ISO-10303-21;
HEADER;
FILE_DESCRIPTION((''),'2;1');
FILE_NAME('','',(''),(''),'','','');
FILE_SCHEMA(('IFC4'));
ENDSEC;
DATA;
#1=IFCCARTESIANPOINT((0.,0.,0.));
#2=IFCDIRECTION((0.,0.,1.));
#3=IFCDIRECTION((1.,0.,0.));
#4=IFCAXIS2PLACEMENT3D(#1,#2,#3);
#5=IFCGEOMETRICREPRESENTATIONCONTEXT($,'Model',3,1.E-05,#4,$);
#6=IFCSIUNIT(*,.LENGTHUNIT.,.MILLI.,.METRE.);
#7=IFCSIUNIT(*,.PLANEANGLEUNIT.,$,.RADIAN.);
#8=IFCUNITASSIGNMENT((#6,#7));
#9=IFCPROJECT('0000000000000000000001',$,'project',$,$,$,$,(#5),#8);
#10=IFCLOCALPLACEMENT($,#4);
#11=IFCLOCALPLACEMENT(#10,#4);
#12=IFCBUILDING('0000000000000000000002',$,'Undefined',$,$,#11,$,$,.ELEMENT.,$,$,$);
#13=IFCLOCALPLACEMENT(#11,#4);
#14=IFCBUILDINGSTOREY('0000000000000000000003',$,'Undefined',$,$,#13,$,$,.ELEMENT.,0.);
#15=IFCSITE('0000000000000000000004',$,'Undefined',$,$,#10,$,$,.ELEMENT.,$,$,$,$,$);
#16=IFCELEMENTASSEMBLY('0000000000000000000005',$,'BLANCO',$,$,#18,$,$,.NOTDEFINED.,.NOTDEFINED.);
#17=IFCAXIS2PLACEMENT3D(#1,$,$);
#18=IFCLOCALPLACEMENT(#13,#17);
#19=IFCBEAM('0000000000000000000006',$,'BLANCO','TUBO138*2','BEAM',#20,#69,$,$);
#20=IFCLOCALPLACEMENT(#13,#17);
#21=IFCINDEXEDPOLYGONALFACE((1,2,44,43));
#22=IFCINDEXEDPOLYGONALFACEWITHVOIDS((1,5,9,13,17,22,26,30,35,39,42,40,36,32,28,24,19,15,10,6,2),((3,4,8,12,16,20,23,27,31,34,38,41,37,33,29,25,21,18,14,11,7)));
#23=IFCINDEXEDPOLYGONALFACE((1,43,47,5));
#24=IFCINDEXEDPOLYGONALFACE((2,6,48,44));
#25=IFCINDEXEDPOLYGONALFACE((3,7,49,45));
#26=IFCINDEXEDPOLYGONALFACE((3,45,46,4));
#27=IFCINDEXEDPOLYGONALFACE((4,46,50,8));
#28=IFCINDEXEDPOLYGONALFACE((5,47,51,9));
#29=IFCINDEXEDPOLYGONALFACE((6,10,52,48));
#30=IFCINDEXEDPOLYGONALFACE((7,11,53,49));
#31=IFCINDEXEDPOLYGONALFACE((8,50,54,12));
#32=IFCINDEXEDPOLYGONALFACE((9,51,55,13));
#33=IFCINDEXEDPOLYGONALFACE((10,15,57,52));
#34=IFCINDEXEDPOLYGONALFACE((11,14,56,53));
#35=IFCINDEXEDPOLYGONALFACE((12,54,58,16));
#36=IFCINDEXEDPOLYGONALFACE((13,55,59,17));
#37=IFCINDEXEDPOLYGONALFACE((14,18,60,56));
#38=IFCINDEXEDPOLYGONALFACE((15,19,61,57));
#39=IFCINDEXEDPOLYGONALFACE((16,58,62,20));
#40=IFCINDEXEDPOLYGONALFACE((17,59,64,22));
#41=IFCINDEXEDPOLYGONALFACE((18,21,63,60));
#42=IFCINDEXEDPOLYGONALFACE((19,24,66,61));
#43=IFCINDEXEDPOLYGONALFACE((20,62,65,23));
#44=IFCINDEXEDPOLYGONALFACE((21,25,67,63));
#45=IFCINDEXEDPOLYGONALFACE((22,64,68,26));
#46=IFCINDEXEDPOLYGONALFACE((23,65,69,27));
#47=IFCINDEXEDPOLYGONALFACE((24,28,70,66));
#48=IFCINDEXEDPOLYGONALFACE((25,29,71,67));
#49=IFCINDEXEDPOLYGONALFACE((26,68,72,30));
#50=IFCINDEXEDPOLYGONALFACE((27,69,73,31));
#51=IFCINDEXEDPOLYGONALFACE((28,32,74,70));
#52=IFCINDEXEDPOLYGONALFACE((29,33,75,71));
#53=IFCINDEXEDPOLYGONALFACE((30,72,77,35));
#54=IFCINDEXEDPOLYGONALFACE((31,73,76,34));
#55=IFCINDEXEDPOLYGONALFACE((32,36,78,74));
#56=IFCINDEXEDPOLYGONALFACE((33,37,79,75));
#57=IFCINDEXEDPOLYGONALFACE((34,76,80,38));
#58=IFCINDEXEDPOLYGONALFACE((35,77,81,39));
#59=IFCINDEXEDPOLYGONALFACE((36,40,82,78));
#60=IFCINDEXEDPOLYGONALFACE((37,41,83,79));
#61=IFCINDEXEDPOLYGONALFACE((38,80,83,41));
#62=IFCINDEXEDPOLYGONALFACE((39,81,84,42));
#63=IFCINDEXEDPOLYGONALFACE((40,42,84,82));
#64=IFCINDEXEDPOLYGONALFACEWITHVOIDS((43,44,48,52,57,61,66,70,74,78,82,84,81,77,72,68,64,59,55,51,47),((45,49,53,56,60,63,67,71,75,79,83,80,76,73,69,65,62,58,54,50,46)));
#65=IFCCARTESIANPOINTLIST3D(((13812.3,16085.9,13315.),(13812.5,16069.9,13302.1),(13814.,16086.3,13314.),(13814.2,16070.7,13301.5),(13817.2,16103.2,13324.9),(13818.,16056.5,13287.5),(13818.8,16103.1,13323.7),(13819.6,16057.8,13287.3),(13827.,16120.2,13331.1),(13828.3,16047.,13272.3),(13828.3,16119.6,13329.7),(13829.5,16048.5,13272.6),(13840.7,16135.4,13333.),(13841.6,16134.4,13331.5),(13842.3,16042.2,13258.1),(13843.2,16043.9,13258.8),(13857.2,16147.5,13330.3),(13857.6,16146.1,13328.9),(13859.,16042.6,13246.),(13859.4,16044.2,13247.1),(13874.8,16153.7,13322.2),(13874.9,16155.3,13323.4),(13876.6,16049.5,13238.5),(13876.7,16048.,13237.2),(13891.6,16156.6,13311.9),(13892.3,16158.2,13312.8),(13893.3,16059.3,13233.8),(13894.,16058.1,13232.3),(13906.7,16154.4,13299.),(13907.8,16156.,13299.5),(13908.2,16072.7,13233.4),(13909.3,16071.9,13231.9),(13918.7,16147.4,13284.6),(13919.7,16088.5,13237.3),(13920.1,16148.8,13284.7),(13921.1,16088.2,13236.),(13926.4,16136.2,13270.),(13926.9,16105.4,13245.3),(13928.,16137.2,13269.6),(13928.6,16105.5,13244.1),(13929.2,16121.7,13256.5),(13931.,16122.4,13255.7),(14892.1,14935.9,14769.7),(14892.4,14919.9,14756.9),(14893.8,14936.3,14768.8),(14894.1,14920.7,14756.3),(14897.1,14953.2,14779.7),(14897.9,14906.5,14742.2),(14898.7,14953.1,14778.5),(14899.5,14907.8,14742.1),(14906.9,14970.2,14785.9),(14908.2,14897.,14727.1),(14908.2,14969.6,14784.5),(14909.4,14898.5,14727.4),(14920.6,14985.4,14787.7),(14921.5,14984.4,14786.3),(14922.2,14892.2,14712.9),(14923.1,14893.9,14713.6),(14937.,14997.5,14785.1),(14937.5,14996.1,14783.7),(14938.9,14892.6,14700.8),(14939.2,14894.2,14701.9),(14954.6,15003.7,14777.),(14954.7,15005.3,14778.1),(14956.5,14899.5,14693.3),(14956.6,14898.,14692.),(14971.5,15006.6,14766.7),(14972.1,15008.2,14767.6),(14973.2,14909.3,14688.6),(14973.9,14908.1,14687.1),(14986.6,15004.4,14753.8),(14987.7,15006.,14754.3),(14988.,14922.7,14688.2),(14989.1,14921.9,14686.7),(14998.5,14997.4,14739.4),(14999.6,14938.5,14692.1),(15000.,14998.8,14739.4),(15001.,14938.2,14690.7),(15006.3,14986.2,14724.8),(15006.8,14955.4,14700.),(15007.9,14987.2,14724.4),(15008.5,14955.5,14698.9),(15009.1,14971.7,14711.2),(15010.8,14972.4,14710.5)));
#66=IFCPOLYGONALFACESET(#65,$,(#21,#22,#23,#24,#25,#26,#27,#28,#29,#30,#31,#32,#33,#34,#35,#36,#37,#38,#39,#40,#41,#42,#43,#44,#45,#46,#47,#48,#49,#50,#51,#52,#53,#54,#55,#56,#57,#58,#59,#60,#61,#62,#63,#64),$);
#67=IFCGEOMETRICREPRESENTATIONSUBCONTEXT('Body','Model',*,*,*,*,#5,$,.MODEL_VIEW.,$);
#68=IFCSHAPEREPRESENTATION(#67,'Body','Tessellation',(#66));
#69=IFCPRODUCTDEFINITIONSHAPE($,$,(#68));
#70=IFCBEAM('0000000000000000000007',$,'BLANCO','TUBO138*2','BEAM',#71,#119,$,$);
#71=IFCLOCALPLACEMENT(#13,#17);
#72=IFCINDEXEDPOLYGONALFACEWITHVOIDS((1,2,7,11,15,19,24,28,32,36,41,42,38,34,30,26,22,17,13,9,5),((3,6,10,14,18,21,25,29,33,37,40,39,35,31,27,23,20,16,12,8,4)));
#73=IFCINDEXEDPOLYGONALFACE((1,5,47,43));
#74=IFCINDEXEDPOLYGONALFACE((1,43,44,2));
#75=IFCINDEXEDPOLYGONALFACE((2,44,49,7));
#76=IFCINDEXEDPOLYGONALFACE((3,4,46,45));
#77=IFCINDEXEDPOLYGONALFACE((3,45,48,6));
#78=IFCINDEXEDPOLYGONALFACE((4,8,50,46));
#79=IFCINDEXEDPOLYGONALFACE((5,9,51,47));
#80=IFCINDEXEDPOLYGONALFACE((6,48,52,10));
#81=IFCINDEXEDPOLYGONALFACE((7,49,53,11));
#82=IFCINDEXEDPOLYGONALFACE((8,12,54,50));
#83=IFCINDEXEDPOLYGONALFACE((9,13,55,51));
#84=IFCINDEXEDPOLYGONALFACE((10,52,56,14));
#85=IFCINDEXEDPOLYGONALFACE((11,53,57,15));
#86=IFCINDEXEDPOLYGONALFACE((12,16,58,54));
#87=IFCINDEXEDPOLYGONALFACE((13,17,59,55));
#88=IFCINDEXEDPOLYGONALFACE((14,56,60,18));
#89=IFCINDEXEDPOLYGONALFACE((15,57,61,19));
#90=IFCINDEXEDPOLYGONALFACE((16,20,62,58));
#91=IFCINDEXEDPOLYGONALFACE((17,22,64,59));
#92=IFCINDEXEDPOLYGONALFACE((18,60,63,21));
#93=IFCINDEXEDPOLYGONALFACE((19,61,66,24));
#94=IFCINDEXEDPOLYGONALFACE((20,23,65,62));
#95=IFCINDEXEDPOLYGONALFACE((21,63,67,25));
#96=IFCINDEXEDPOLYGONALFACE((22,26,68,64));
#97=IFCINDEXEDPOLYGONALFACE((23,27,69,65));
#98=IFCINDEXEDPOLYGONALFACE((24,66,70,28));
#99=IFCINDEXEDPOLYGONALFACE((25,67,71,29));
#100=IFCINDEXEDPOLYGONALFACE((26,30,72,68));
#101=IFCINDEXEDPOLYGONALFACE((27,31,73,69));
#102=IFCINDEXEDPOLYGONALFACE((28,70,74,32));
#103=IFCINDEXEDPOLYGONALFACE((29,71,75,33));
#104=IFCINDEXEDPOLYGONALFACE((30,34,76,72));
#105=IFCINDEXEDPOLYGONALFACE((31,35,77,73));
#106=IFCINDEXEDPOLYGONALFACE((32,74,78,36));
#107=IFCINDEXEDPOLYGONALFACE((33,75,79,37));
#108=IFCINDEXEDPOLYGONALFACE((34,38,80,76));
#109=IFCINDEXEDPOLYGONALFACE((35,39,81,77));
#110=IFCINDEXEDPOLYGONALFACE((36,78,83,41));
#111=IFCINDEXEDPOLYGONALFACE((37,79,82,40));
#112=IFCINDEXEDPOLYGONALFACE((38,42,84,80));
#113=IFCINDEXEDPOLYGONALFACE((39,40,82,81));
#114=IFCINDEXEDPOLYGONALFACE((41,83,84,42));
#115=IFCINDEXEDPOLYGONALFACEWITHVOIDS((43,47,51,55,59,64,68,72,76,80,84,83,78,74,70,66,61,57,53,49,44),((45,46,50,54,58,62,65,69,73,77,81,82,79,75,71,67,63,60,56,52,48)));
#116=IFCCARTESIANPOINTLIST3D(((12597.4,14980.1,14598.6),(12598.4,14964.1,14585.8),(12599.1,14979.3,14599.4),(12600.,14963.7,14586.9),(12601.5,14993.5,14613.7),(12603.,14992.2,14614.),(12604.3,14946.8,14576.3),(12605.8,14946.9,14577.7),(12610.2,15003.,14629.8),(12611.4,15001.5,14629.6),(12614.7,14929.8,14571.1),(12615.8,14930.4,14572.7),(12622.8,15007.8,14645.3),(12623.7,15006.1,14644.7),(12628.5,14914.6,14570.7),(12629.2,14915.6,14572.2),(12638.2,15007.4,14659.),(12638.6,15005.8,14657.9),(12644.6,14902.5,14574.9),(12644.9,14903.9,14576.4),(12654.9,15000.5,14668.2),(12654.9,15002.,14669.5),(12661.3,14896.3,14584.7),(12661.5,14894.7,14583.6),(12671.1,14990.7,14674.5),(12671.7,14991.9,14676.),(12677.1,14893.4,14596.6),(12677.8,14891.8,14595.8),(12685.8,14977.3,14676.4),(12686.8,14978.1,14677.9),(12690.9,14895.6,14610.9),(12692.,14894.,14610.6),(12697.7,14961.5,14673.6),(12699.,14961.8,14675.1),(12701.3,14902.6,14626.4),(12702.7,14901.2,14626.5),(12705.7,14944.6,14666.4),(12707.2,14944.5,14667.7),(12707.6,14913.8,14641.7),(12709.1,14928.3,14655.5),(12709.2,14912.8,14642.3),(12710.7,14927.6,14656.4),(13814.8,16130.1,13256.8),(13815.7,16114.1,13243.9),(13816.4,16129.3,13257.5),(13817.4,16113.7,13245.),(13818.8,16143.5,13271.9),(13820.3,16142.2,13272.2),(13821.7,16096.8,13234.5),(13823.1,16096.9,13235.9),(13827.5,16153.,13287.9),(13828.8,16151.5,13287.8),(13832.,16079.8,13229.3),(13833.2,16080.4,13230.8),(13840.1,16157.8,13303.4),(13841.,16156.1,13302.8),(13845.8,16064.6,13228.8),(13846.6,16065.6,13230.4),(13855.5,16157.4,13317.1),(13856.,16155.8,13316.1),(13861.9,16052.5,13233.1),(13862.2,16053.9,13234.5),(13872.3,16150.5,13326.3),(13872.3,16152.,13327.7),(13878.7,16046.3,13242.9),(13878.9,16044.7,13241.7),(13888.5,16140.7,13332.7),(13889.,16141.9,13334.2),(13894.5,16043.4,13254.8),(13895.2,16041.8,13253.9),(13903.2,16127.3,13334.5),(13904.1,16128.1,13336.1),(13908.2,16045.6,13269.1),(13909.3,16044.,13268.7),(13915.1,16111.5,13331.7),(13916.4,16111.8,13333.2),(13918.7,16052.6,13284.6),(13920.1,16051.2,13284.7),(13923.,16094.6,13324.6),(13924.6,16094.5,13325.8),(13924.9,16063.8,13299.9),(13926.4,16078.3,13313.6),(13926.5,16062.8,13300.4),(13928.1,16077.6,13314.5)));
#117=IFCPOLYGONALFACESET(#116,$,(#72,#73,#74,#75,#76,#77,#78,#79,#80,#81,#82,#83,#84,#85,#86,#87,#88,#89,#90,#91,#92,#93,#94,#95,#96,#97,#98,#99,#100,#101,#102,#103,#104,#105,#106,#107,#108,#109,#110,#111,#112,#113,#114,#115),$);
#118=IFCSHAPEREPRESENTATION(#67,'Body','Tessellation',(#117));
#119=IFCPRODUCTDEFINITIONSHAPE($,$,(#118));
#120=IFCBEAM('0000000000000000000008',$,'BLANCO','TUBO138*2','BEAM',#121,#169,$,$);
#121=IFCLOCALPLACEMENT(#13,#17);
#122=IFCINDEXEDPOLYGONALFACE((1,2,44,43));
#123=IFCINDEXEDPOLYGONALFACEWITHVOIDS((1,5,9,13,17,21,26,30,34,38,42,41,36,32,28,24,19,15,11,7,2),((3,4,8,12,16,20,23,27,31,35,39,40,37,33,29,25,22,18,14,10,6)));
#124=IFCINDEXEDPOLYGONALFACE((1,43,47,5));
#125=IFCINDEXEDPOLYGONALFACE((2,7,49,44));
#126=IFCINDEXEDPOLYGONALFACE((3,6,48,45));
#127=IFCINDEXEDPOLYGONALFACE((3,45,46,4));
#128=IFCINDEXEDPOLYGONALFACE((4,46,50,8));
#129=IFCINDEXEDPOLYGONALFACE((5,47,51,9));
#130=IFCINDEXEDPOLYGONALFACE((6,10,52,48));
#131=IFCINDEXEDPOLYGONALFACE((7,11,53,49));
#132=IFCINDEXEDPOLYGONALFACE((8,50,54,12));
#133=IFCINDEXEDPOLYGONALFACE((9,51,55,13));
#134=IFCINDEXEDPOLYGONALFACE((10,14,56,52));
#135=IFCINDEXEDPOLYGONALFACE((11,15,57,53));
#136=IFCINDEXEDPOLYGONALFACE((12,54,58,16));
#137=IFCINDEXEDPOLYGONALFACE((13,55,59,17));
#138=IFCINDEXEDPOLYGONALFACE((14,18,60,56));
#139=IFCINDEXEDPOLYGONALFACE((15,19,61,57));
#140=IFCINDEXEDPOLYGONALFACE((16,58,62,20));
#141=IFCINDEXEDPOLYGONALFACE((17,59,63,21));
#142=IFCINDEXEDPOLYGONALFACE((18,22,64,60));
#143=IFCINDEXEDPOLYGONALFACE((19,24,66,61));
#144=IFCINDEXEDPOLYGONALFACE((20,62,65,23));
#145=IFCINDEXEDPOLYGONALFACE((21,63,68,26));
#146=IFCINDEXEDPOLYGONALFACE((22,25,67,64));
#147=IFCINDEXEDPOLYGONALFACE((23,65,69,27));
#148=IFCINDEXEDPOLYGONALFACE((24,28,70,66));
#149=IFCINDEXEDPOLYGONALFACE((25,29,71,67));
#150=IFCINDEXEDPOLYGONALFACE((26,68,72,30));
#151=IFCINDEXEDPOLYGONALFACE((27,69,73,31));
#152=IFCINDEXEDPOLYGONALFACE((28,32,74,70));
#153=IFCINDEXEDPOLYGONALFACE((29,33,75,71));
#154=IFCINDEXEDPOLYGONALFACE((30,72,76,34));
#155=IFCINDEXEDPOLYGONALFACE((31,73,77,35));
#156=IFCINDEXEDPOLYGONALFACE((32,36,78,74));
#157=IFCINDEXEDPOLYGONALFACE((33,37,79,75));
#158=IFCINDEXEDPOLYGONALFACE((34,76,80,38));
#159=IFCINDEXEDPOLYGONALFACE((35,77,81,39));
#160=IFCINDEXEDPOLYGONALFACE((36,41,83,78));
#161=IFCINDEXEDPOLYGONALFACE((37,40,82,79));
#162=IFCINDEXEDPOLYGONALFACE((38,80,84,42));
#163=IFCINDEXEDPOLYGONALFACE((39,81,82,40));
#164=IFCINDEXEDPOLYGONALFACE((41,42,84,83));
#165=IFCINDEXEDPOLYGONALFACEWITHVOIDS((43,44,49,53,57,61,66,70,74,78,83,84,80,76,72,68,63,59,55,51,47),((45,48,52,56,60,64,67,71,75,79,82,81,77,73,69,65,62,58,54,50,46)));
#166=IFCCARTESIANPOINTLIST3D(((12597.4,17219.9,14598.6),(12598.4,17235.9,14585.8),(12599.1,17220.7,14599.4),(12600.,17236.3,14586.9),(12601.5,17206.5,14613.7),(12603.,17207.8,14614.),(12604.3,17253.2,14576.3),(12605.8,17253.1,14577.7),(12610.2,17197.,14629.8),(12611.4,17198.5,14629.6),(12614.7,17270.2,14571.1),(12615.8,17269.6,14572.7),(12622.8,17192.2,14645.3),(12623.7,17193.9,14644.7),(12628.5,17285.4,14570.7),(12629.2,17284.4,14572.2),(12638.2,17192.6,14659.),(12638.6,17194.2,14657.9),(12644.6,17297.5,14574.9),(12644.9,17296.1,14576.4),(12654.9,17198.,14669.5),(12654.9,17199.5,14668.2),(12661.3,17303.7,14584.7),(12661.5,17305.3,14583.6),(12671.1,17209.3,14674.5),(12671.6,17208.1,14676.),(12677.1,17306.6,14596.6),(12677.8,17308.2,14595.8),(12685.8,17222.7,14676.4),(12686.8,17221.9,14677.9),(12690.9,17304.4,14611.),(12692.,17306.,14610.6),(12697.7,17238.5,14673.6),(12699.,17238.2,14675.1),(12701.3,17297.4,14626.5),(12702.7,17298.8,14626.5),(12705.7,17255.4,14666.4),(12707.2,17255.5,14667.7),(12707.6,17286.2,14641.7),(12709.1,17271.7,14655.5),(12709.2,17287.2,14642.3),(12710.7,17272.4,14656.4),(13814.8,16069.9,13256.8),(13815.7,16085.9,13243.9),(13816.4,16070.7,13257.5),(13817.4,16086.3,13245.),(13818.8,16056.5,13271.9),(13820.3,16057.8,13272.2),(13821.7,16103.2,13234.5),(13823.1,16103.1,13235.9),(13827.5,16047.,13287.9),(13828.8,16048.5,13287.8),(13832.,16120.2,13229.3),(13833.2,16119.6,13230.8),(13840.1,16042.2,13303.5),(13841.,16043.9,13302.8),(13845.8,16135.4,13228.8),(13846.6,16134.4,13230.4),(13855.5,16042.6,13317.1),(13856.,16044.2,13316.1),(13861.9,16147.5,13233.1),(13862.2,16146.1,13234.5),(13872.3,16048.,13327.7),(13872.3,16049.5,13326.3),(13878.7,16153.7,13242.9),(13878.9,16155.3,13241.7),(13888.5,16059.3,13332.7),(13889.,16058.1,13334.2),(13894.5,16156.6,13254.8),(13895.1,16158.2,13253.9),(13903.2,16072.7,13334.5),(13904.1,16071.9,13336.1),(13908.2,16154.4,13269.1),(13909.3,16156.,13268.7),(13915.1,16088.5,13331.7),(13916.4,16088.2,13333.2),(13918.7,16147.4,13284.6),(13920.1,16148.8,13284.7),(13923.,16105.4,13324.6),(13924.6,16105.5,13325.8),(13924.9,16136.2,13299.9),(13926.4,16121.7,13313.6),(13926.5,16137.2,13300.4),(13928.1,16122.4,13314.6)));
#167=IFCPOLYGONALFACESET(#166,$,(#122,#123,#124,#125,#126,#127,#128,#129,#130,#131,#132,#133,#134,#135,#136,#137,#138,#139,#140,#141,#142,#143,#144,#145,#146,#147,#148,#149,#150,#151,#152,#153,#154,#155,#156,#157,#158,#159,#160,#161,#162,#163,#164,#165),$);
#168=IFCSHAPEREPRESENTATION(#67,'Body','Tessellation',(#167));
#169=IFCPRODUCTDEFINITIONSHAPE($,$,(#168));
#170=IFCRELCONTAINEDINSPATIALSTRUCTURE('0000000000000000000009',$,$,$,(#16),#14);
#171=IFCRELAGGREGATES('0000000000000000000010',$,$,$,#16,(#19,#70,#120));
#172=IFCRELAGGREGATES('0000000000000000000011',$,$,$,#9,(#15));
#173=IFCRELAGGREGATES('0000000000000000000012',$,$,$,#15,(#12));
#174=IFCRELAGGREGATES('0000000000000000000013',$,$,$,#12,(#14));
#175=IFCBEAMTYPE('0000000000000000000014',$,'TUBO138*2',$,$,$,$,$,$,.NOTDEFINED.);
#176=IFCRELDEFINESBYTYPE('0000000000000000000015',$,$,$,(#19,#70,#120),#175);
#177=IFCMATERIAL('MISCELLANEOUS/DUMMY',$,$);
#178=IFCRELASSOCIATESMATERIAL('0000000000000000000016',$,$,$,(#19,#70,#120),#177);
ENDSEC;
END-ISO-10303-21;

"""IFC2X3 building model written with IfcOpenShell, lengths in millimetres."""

from ifc_helpers import new_model, si_unit, frame, origin_with_axes, origin_2d_with_axis, place, context, subcontext, project, spatial, hollow_circle, extrude, material, type_object, element, aggregate, save


model = new_model("IFC2X3")

# Units and contexts
model_context = context("Model", 3, precision=1e-05, world=origin_with_axes())
body_context = subcontext(model_context, "Body", "Model", "MODEL_VIEW")
ifc_project = project(units=[si_unit("LENGTHUNIT", "METRE", prefix="MILLI"), si_unit("PLANEANGLEUNIT", "RADIAN")], contexts=[model_context])

# Site, building, storey
site_placement = place(None, origin_with_axes())
site = spatial("IfcSite", under=ifc_project, at=site_placement, Name="Undefined", CompositionType="ELEMENT")
building_placement = place(site_placement, origin_with_axes())
building = spatial("IfcBuilding", under=site, at=building_placement, Name="Undefined", CompositionType="ELEMENT")
storey_placement = place(building_placement, origin_with_axes())
storey = spatial("IfcBuildingStorey", under=building, at=storey_placement, Name="Undefined", CompositionType="ELEMENT", Elevation=0.0)

# Element assembly, beams
assembly_placement = place(storey_placement, origin_with_axes())
assembly = element("IfcElementAssembly", 1, at=assembly_placement, inside=storey, Name="BLANCO", AssemblyPlace="NOTDEFINED", PredefinedType="NOTDEFINED")
ifc_material = material(Name="MISCELLANEOUS/DUMMY")
beam_type = type_object("IfcBeamType", Name="TUBO138*2", PredefinedType="NOTDEFINED")
beam_1_placement = place(assembly_placement, frame((13871.3, 16100.0, 13282.3), z_axis=(0.497966, -0.461316, -0.734314), x_axis=(0.503224, -0.535899, 0.677922)))
beam_1 = element("IfcBeam", 2, at=beam_1_placement, type_object=beam_type, material=ifc_material, Name="BLANCO", Description="TUBO138*2", ObjectType="BEAM", context=body_context, shape_type="SweptSolid", body=[
    extrude(hollow_circle(Radius=69.0, WallThickness=2.0, at=origin_2d_with_axis()), frame((2145.9, 0.0, 0.0), z_axis=(-1.0, 0.0, 0.0), x_axis=(0.0, -1.0, 0.0)), (0.0, 0.0, 1.0), 2145.9),
])
beam_2_placement = place(assembly_placement, frame((13871.3, 16100.0, 13282.3), z_axis=(-0.423552, -0.461316, -0.77961), x_axis=(-0.567282, -0.535899, 0.625303)))
beam_2 = element("IfcBeam", 3, at=beam_2_placement, type_object=beam_type, material=ifc_material, Name="BLANCO", Description="TUBO138*2", ObjectType="BEAM", context=body_context, shape_type="SweptSolid", body=[
    extrude(hollow_circle(Radius=69.0, WallThickness=2.0, at=origin_2d_with_axis()), frame((2145.9, 0.0, 0.0), z_axis=(-1.0, 0.0, 0.0), x_axis=(0.0, -1.0, 0.0)), (0.0, 0.0, 1.0), 2145.9),
])
beam_3_placement = place(assembly_placement, frame((12654.0, 17250.0, 14624.1), z_axis=(-0.423552, 0.461316, -0.77961), x_axis=(0.567282, -0.535899, -0.625303)))
beam_3 = element("IfcBeam", 4, at=beam_3_placement, type_object=beam_type, material=ifc_material, Name="BLANCO", Description="TUBO138*2", ObjectType="BEAM", context=body_context, shape_type="SweptSolid", body=[
    extrude(hollow_circle(Radius=69.0, WallThickness=2.0, at=origin_2d_with_axis()), frame((2145.9, 0.0, 0.0), z_axis=(-1.0, 0.0, 0.0), x_axis=(0.0, -1.0, 0.0)), (0.0, 0.0, 1.0), 2145.9),
])
aggregate(assembly, [beam_1, beam_2, beam_3])

save(model, "model.ifc")
